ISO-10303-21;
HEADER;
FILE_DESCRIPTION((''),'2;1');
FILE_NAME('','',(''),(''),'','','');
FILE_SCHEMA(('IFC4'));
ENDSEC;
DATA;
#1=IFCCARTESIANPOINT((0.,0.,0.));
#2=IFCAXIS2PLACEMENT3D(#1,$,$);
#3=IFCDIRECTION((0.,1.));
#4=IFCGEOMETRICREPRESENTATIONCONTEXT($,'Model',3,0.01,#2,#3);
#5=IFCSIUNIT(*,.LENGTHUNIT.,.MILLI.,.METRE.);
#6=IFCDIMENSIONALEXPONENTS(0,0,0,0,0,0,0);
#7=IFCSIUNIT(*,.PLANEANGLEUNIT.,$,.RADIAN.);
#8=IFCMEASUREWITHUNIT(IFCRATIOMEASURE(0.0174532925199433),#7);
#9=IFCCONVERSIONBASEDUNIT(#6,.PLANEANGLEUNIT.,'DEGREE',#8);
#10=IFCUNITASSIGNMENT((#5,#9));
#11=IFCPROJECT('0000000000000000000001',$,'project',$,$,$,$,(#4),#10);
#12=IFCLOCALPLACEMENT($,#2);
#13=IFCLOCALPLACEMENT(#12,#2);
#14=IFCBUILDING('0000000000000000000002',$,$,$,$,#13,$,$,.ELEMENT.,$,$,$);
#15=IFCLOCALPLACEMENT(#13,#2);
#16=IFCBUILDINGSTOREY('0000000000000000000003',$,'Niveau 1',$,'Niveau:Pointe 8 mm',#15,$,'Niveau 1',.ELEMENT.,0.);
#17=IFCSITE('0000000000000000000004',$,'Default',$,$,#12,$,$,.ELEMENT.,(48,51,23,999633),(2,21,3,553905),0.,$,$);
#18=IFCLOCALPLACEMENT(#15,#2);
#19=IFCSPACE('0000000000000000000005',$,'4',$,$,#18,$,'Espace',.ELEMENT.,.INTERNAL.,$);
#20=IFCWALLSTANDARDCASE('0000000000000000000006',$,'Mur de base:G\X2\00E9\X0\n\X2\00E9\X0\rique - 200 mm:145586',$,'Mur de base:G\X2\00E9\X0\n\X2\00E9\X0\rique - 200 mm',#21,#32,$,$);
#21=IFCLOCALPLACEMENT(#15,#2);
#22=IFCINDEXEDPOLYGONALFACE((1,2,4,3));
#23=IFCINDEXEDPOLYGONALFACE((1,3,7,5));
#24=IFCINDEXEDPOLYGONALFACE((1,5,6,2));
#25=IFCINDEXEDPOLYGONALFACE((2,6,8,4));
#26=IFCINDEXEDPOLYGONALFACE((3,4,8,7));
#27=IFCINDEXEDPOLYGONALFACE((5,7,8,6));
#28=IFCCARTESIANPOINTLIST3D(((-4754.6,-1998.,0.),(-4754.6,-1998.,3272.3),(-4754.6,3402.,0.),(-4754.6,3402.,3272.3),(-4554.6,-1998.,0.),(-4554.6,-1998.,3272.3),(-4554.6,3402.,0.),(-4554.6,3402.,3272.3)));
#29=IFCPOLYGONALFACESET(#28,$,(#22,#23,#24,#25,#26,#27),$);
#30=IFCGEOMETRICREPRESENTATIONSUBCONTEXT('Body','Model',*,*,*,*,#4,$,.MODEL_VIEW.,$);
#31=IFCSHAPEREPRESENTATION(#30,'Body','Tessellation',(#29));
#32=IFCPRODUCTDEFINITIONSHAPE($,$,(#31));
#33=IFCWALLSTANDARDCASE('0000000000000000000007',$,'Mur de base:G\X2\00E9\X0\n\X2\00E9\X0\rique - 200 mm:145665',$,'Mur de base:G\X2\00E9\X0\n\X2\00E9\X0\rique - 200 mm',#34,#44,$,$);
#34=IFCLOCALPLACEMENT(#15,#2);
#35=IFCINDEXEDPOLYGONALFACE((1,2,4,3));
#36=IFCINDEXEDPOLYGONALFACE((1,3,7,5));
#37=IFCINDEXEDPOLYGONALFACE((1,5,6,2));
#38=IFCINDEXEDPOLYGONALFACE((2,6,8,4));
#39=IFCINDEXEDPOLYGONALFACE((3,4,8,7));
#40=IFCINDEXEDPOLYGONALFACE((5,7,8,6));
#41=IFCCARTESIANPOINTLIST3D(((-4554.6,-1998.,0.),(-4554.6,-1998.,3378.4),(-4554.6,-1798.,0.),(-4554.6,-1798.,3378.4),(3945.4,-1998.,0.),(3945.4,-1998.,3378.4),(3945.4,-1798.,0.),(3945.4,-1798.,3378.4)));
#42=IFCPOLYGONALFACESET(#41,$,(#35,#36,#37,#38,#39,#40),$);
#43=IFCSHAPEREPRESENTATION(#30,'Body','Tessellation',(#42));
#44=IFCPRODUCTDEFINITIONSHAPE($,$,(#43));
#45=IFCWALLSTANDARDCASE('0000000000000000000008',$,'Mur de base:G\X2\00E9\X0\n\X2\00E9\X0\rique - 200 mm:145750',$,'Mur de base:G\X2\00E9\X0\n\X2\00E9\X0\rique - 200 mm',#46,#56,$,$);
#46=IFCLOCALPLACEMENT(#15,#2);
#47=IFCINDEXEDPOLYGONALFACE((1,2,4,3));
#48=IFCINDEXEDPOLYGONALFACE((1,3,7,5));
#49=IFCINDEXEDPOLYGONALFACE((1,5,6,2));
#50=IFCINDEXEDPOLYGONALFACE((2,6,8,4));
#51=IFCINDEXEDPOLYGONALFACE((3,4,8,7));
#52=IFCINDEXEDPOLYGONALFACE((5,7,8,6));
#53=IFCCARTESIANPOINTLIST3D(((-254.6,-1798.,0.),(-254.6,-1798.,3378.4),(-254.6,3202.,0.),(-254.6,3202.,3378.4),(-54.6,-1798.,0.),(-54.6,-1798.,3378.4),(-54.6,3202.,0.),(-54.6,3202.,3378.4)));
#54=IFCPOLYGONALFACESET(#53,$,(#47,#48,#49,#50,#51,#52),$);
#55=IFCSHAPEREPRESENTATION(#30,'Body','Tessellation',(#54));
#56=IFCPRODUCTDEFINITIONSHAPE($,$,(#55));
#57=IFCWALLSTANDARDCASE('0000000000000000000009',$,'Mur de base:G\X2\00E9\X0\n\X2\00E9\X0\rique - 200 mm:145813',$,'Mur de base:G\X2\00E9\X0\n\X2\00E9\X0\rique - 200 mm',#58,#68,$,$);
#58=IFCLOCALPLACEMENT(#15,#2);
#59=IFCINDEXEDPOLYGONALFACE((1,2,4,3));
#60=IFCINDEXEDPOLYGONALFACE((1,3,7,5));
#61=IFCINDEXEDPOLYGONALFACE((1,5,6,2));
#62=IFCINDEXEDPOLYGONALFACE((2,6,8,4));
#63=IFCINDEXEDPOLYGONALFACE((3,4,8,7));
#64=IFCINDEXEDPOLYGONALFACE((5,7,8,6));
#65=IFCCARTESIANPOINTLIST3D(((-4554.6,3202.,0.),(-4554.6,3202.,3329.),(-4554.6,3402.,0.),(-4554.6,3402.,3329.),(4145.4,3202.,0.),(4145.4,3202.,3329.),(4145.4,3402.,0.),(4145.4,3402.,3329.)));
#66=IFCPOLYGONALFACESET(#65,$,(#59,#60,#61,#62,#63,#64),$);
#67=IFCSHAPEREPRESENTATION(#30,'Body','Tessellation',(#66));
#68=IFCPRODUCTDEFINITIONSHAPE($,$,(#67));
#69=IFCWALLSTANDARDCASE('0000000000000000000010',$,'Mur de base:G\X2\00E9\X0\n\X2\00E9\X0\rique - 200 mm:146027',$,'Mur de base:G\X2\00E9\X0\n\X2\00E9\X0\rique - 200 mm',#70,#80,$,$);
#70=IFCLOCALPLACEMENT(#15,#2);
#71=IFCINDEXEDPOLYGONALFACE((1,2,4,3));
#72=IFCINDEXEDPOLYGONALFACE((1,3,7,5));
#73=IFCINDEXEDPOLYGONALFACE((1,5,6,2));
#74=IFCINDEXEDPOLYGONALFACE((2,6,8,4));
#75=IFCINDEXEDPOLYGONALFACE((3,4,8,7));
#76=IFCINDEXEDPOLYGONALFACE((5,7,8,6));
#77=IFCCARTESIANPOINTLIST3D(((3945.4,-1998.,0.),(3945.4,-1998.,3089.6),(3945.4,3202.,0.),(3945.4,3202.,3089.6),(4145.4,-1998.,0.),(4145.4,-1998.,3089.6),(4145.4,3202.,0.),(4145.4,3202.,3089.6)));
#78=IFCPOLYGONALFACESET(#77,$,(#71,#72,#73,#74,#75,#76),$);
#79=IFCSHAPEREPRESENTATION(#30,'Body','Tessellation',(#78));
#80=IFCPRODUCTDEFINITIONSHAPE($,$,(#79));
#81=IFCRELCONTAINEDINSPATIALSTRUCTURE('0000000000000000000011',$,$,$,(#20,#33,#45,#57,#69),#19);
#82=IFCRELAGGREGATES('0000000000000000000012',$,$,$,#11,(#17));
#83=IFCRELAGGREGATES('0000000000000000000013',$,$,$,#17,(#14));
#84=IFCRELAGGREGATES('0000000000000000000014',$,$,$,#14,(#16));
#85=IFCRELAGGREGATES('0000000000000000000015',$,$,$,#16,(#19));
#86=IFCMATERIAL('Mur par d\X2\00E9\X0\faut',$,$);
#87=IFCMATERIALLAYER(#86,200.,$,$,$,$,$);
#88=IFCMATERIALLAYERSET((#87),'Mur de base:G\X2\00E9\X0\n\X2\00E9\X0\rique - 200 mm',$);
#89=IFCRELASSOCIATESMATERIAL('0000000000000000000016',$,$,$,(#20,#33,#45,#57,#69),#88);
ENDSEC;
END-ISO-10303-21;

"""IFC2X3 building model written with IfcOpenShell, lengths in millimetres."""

from ifc_helpers import new_model, entity, si_unit, converted_unit, direction, frame, frame_2d, origin, place, context, subcontext, project, spatial, rectangle, extrude, material, layer, layer_set, layer_usage, element, save


model = new_model("IFC2X3")

# Units and contexts
model_context = context("Model", 3, precision=0.01, world=origin(), true_north=direction((0.0, 1.0)))
body_context = subcontext(model_context, "Body", "Model", "MODEL_VIEW")
ifc_project = project(units=[si_unit("LENGTHUNIT", "METRE", prefix="MILLI"), converted_unit("PLANEANGLEUNIT", "DEGREE", entity("IfcRatioMeasure", 0.0174532925199433), si_unit("PLANEANGLEUNIT", "RADIAN"), dimensions=[0, 0, 0, 0, 0, 0, 0])], contexts=[model_context])

# Site, building, storey, space
site_placement = place(None, origin())
site = spatial("IfcSite", under=ifc_project, at=site_placement, Name="Default", CompositionType="ELEMENT", RefLatitude=(48, 51, 23, 999633), RefLongitude=(2, 21, 3, 553905), RefElevation=0.0)
building_placement = place(site_placement, origin())
building = spatial("IfcBuilding", under=site, at=building_placement, CompositionType="ELEMENT")
storey_placement = place(building_placement, origin())
storey = spatial("IfcBuildingStorey", under=building, at=storey_placement, Name="Niveau 1", ObjectType="Niveau:Pointe 8 mm", LongName="Niveau 1", CompositionType="ELEMENT", Elevation=0.0)
space_placement = place(storey_placement, origin())
space = spatial("IfcSpace", under=storey, at=space_placement, Name="4", LongName="Espace", CompositionType="ELEMENT", InteriorOrExteriorSpace="INTERNAL")

# Walls
ifc_material = material(Name="Mur par défaut")
ifc_layer = layer(ifc_material, 200.0)
ifc_layer_set = layer_set([ifc_layer], Name="Mur de base:Générique - 200 mm")
ifc_layer_usage_1 = layer_usage(ifc_layer_set, "AXIS2", "NEGATIVE", 100.0)
wall_1_placement = place(storey_placement, frame((-4654.6, 3402.0, 0.0), z_axis=(0.0, 0.0, 1.0), x_axis=(0.0, -1.0, 0.0)))
element("IfcWallStandardCase", 1, at=wall_1_placement, inside=space, material=ifc_layer_usage_1, Name="Mur de base:Générique - 200 mm:145586", ObjectType="Mur de base:Générique - 200 mm", context=body_context, shape_type="SweptSolid", body=[
    extrude(rectangle(XDim=5400.0, YDim=200.0, at=frame_2d((2700.0, 0.0), x_axis=(-1.0, 0.0))), origin(), (0.0, 0.0, 1.0), 3272.3),
])
ifc_layer_usage_2 = layer_usage(ifc_layer_set, "AXIS2", "NEGATIVE", 100.0)
wall_2_placement = place(storey_placement, frame((-4554.6, -1898.0, 0.0)))
element("IfcWallStandardCase", 2, at=wall_2_placement, inside=space, material=ifc_layer_usage_2, Name="Mur de base:Générique - 200 mm:145665", ObjectType="Mur de base:Générique - 200 mm", context=body_context, shape_type="SweptSolid", body=[
    extrude(rectangle(XDim=8500.0, YDim=200.0, at=frame_2d((4250.0, 0.0), x_axis=(-1.0, 0.0))), origin(), (0.0, 0.0, 1.0), 3378.4),
])
ifc_layer_usage_3 = layer_usage(ifc_layer_set, "AXIS2", "NEGATIVE", 100.0)
wall_3_placement = place(storey_placement, frame((-154.6, -1798.0, 0.0), z_axis=(0.0, 0.0, 1.0), x_axis=(0.0, 1.0, 0.0)))
element("IfcWallStandardCase", 3, at=wall_3_placement, inside=space, material=ifc_layer_usage_3, Name="Mur de base:Générique - 200 mm:145750", ObjectType="Mur de base:Générique - 200 mm", context=body_context, shape_type="SweptSolid", body=[
    extrude(rectangle(XDim=5000.0, YDim=200.0, at=frame_2d((2500.0, 0.0), x_axis=(-1.0, 0.0))), origin(), (0.0, 0.0, 1.0), 3378.4),
])
ifc_layer_usage_4 = layer_usage(ifc_layer_set, "AXIS2", "NEGATIVE", 100.0)
wall_4_placement = place(storey_placement, frame((4145.4, 3302.0, 0.0), z_axis=(0.0, 0.0, 1.0), x_axis=(-1.0, 0.0, 0.0)))
element("IfcWallStandardCase", 4, at=wall_4_placement, inside=space, material=ifc_layer_usage_4, Name="Mur de base:Générique - 200 mm:145813", ObjectType="Mur de base:Générique - 200 mm", context=body_context, shape_type="SweptSolid", body=[
    extrude(rectangle(XDim=8700.0, YDim=200.0, at=frame_2d((4350.0, 0.0), x_axis=(-1.0, 0.0))), origin(), (0.0, 0.0, 1.0), 3329.0),
])
ifc_layer_usage_5 = layer_usage(ifc_layer_set, "AXIS2", "NEGATIVE", 100.0)
wall_5_placement = place(storey_placement, frame((4045.4, 3202.0, 0.0), z_axis=(0.0, 0.0, 1.0), x_axis=(0.0, -1.0, 0.0)))
element("IfcWallStandardCase", 5, at=wall_5_placement, inside=space, material=ifc_layer_usage_5, Name="Mur de base:Générique - 200 mm:146027", ObjectType="Mur de base:Générique - 200 mm", context=body_context, shape_type="SweptSolid", body=[
    extrude(rectangle(XDim=5200.0, YDim=200.0, at=frame_2d((2600.0, 0.0), x_axis=(-1.0, 0.0))), origin(), (0.0, 0.0, 1.0), 3089.6),
])

save(model, "model.ifc")
